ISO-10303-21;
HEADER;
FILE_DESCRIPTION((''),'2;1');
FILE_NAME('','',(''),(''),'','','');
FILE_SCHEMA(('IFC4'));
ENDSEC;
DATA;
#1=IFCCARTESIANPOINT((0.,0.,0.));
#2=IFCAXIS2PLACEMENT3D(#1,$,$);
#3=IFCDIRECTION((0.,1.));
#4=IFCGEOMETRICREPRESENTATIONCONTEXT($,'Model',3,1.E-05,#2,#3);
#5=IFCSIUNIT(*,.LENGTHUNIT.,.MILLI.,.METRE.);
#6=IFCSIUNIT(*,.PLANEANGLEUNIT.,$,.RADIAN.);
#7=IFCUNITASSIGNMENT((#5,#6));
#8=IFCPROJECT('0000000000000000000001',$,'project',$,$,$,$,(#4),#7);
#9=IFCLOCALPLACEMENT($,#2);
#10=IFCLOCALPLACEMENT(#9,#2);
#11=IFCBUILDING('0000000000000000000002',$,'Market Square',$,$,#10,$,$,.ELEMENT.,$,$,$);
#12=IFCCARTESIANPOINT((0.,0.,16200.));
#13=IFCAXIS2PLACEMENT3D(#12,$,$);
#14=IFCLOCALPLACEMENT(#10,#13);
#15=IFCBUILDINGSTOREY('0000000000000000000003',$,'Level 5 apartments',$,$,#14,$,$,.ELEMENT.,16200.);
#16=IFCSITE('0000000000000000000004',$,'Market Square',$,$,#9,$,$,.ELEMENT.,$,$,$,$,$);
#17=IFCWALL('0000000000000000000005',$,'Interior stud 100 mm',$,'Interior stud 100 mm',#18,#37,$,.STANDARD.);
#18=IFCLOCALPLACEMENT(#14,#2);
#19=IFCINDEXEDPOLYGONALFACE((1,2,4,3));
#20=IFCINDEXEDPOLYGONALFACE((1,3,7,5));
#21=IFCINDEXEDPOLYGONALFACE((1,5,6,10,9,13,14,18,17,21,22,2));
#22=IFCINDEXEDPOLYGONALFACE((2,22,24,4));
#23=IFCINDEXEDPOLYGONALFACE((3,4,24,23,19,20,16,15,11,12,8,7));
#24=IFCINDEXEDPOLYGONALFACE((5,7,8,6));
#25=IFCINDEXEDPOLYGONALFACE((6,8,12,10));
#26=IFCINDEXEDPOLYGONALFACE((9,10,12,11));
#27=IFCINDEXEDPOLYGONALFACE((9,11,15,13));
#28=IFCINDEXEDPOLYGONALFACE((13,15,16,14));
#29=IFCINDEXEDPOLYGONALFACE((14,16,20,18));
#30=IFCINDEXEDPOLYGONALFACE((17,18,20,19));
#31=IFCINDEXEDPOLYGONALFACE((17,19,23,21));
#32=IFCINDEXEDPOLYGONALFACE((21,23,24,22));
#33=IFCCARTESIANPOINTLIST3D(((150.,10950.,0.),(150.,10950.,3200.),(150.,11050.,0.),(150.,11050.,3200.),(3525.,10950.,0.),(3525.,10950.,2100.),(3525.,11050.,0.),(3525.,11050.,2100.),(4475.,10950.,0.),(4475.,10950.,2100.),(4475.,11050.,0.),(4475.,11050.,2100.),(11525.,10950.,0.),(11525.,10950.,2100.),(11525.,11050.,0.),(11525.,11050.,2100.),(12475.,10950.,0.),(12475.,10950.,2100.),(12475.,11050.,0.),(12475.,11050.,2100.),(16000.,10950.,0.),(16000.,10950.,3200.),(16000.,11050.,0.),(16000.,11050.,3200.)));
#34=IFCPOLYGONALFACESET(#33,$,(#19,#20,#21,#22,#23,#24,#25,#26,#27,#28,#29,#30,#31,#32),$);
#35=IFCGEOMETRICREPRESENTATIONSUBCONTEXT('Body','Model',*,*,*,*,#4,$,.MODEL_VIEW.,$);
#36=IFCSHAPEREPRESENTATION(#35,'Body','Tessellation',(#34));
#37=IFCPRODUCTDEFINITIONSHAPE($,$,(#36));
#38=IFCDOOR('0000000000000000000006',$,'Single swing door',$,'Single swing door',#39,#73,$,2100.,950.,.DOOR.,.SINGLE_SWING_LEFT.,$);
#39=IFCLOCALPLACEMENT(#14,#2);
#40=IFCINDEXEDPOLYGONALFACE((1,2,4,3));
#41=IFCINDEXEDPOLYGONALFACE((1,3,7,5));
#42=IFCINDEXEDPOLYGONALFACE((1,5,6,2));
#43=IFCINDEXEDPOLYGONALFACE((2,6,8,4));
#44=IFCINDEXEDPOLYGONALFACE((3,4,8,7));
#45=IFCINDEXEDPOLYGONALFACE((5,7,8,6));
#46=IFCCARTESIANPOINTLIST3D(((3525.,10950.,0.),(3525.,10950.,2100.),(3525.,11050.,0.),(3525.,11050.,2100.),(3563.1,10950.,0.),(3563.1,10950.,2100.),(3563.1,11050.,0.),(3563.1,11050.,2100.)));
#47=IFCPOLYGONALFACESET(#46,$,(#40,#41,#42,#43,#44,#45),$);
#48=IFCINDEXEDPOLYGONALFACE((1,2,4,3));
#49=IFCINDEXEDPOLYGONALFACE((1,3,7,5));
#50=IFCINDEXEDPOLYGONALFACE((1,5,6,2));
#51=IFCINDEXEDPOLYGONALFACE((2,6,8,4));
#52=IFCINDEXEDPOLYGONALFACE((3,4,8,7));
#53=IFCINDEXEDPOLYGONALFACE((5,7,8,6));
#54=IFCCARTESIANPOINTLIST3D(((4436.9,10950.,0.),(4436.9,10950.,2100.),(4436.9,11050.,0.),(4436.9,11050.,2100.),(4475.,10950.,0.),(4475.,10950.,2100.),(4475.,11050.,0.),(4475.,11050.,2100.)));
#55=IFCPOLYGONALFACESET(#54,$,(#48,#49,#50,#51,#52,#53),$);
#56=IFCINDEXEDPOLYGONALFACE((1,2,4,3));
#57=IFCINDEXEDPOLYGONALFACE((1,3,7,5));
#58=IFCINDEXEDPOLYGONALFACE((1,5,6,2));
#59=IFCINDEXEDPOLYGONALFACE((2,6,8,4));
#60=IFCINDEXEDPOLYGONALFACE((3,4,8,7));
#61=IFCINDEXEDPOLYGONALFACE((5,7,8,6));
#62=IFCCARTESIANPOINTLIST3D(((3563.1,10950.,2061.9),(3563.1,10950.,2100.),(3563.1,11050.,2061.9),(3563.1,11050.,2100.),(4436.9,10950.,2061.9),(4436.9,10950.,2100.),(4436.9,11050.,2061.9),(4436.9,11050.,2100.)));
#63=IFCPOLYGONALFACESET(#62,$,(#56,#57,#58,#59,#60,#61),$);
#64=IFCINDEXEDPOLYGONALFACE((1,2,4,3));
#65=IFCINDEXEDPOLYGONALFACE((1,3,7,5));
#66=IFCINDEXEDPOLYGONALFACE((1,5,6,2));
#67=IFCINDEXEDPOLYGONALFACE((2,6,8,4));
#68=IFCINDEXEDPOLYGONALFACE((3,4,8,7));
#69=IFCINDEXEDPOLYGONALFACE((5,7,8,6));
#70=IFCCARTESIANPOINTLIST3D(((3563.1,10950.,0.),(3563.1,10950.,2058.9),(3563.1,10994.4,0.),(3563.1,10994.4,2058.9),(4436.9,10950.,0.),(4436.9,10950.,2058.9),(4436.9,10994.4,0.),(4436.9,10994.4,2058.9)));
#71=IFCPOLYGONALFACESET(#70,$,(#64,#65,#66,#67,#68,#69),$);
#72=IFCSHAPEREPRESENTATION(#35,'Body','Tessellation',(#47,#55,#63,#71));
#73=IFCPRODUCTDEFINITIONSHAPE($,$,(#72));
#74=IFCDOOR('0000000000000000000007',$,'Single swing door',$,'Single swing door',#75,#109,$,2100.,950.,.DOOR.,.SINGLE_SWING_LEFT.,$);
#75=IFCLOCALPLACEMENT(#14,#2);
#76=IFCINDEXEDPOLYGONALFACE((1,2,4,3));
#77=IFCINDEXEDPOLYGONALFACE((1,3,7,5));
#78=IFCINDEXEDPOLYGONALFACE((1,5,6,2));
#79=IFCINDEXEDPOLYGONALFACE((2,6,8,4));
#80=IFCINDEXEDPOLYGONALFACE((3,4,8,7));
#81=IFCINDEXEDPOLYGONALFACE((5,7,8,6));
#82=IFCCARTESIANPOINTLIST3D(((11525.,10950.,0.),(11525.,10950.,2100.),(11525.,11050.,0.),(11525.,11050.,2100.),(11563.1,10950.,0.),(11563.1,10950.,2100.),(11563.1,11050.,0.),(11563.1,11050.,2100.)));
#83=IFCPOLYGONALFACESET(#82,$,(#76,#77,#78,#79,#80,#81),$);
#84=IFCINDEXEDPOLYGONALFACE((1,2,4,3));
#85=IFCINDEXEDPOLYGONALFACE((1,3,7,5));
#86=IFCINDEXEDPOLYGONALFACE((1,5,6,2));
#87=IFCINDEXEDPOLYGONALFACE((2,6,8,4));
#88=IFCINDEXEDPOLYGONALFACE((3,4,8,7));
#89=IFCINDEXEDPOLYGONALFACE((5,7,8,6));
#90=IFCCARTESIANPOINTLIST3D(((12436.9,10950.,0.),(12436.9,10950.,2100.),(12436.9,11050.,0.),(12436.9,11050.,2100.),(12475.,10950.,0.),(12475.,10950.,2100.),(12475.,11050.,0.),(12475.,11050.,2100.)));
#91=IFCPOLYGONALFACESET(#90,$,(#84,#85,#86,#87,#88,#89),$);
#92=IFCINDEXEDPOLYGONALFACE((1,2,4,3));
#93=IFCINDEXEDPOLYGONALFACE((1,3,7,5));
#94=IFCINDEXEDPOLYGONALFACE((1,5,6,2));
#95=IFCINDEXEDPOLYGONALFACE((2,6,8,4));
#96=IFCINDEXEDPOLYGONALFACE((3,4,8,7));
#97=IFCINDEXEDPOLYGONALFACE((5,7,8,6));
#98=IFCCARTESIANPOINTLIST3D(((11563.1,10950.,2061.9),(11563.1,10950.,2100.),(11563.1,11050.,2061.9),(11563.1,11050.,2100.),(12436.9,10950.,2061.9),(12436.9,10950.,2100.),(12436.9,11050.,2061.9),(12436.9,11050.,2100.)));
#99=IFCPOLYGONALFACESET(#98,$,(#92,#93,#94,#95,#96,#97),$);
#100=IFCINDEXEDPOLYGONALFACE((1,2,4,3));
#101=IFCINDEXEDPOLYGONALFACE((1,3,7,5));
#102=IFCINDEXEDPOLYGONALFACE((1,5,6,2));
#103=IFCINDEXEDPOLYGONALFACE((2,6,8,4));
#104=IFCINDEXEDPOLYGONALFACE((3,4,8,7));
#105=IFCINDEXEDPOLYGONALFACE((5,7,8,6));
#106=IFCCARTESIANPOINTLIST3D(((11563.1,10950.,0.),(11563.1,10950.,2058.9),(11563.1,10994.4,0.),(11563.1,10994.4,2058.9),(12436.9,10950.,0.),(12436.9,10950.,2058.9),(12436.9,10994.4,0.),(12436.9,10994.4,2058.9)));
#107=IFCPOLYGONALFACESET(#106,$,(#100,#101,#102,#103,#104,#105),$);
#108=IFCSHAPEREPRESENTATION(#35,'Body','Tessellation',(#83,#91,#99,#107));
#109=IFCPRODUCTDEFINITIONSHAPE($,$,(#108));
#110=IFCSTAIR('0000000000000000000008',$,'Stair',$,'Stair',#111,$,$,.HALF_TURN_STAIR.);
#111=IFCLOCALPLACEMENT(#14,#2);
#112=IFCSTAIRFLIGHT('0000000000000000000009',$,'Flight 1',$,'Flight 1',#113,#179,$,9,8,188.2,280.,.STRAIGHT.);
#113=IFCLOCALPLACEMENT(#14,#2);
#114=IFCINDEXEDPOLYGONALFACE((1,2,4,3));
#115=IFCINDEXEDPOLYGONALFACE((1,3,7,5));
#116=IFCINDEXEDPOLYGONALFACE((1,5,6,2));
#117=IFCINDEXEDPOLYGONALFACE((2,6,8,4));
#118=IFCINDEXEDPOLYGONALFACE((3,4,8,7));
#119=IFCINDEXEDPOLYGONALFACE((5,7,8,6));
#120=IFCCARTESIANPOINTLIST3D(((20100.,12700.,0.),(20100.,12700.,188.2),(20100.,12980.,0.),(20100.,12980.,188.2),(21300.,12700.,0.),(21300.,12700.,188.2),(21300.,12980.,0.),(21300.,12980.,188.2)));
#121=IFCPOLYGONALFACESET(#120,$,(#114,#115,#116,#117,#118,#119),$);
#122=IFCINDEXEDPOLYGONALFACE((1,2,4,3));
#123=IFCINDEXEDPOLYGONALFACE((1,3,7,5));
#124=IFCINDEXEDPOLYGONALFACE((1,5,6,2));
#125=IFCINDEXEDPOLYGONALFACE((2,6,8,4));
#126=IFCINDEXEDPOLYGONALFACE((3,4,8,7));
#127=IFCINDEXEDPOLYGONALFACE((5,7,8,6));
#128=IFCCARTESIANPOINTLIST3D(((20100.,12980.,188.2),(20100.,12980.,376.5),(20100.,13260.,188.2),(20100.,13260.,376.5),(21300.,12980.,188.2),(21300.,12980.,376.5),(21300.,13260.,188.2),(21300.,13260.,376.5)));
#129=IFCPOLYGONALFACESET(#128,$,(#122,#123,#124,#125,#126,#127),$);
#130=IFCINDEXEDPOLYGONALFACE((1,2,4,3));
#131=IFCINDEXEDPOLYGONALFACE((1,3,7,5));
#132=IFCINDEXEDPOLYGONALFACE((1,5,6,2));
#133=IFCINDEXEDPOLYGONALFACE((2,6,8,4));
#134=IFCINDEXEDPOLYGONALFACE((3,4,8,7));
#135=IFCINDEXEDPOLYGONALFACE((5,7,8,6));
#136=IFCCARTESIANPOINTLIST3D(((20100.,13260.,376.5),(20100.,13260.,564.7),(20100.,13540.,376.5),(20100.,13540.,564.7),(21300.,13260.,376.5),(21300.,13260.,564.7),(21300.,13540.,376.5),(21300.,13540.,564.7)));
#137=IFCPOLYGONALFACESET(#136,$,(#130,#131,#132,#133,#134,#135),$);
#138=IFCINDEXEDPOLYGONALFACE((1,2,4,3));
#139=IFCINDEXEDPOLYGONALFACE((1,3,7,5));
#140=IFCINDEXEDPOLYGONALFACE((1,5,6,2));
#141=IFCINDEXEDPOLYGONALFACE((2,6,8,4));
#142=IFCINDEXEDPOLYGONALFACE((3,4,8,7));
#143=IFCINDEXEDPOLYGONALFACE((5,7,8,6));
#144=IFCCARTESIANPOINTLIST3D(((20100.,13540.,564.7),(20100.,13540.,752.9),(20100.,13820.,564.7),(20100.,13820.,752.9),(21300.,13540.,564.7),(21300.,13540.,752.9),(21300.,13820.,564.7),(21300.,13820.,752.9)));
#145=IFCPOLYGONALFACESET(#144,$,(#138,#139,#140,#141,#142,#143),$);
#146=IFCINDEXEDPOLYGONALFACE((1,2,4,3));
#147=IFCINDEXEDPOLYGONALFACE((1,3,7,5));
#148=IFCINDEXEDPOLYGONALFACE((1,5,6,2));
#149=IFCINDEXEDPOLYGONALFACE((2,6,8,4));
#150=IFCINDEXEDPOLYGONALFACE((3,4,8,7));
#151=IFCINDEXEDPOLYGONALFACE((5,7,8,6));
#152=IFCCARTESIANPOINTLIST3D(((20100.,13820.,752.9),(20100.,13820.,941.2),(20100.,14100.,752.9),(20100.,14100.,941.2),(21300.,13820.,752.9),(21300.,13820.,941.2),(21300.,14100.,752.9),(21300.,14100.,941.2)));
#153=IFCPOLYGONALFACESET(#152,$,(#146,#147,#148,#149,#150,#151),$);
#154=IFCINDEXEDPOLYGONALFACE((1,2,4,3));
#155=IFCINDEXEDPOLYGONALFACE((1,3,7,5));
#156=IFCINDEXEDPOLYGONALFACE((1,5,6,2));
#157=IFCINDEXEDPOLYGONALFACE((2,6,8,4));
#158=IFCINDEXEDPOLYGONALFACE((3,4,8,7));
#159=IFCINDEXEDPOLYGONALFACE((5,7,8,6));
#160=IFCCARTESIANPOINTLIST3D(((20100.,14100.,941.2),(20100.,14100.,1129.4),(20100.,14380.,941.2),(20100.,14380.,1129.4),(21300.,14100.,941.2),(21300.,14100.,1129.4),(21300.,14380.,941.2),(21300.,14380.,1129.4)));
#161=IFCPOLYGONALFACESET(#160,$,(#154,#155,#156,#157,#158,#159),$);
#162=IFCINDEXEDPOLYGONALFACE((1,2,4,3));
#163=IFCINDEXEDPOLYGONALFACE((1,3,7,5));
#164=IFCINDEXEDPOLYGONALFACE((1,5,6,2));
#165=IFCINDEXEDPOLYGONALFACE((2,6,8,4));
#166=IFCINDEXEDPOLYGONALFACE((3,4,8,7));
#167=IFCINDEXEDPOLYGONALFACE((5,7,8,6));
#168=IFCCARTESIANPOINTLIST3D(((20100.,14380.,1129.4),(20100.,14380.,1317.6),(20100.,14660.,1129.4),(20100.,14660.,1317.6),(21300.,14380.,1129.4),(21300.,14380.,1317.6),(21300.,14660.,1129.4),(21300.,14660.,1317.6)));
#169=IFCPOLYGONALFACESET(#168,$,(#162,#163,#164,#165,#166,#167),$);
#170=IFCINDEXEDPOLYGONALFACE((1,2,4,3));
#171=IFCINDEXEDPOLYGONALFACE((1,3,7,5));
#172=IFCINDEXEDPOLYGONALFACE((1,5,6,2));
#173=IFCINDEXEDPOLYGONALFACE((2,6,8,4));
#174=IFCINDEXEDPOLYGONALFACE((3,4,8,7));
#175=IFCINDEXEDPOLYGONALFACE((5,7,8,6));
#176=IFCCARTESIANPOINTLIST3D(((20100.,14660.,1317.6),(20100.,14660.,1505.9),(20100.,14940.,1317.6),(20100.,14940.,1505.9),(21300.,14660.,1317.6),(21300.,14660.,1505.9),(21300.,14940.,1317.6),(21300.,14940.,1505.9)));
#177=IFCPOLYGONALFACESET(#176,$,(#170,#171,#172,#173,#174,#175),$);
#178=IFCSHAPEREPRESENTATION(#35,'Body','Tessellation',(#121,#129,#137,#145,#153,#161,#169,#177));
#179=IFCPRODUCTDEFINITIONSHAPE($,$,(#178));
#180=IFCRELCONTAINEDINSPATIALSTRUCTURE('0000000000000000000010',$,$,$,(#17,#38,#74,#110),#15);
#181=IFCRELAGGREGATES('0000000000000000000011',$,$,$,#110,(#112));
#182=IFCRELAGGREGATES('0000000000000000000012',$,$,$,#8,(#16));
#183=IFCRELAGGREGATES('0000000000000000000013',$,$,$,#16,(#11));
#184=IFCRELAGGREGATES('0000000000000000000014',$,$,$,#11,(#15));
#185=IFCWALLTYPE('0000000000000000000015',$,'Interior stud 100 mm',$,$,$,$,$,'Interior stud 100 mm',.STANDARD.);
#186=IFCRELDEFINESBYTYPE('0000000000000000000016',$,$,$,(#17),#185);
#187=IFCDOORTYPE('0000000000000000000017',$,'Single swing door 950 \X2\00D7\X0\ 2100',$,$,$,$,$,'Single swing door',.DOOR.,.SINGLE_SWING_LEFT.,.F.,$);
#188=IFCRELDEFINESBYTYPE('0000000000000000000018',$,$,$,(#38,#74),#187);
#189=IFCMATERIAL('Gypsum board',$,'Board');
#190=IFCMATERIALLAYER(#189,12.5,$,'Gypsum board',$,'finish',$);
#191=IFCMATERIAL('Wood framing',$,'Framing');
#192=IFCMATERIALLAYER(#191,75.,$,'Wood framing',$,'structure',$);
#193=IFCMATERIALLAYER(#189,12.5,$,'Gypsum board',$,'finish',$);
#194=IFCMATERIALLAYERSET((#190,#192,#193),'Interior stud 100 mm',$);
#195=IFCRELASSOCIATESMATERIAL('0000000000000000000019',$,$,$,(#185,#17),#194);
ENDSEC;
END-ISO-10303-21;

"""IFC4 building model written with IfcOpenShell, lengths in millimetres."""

from ifc_helpers import new_model, si_unit, direction, frame, origin, origin_with_axes, place, context, subcontext, project, spatial, polyline, outline, extrude, material, layer, layer_set, layer_usage, type_object, element, fill, aggregate, save


model = new_model("IFC4")

# Units and contexts
model_context = context("Model", 3, precision=1e-05, world=origin(), true_north=direction((0.0, 1.0)))
body_context = subcontext(model_context, "Body", "Model", "MODEL_VIEW")
ifc_project = project(units=[si_unit("LENGTHUNIT", "METRE", prefix="MILLI"), si_unit("PLANEANGLEUNIT", "RADIAN")], contexts=[model_context])

# Site, building, storey
site_placement = place(None, origin())
site = spatial("IfcSite", under=ifc_project, at=site_placement, Name="Market Square", CompositionType="ELEMENT")
building_placement = place(site_placement, origin())
building = spatial("IfcBuilding", under=site, at=building_placement, Name="Market Square", CompositionType="ELEMENT")
storey_placement = place(building_placement, frame((0.0, 0.0, 16200.0)))
storey = spatial("IfcBuildingStorey", under=building, at=storey_placement, Name="Level 5 apartments", CompositionType="ELEMENT", Elevation=16200.0)

# Wall, openings, doors
ifc_material_1 = material(Name="Gypsum board", Category="Board")
ifc_layer_1 = layer(ifc_material_1, 12.5, Name="Gypsum board", Category="finish")
ifc_material_2 = material(Name="Wood framing", Category="Framing")
ifc_layer_2 = layer(ifc_material_2, 75.0, Name="Wood framing", Category="structure")
ifc_layer_3 = layer(ifc_material_1, 12.5, Name="Gypsum board", Category="finish")
ifc_layer_set_1 = layer_set([ifc_layer_1, ifc_layer_2, ifc_layer_3], Name="Interior stud 100 mm")
wall_type_1 = type_object("IfcWallType", Name="Interior stud 100 mm", ElementType="Interior stud 100 mm", PredefinedType="STANDARD", material=ifc_layer_set_1)
door_type = type_object("IfcDoorType", Name="Single swing door 950 × 2100", ElementType="Single swing door", OperationType="SINGLE_SWING_LEFT", ParameterTakesPrecedence=False, PredefinedType="DOOR")
ifc_layer_usage_1 = layer_usage(ifc_layer_set_1, "AXIS2", "NEGATIVE", 50.0)
wall_1_placement = place(storey_placement, frame((0.0, 11000.0, 0.0), z_axis=(0.0, 0.0, 1.0), x_axis=(1.0, 0.0, 0.0)))
wall_1 = element("IfcWall", 1, at=wall_1_placement, inside=storey, type_object=wall_type_1, material=ifc_layer_usage_1, Name="Interior stud 100 mm", ObjectType="Interior stud 100 mm", PredefinedType="STANDARD", context=body_context, shape_type="SweptSolid", body=[
    extrude(outline(polyline([(150.0, -50.0), (16000.0, -50.0), (16000.0, 50.0), (150.0, 50.0), (150.0, -50.0)])), origin(), (0.0, 0.0, 1.0), 3200.0),
])
opening_1_placement = place(wall_1_placement, frame((3525.0, 0.0, 0.0), z_axis=(0.0, 0.0, 1.0), x_axis=(1.0, 0.0, 0.0)))
opening_1 = element("IfcOpeningElement", 2, at=opening_1_placement, cuts=wall_1, PredefinedType="OPENING", context=body_context, shape_type="SweptSolid", body=[
    extrude(outline(polyline([(0.0, -60.0), (950.0, -60.0), (950.0, 60.0), (0.0, 60.0), (0.0, -60.0)])), origin(), (0.0, 0.0, 1.0), 2100.0),
])
opening_2_placement = place(wall_1_placement, frame((11525.0, 0.0, 0.0), z_axis=(0.0, 0.0, 1.0), x_axis=(1.0, 0.0, 0.0)))
opening_2 = element("IfcOpeningElement", 3, at=opening_2_placement, cuts=wall_1, PredefinedType="OPENING", context=body_context, shape_type="SweptSolid", body=[
    extrude(outline(polyline([(0.0, -60.0), (950.0, -60.0), (950.0, 60.0), (0.0, 60.0), (0.0, -60.0)])), origin(), (0.0, 0.0, 1.0), 2100.0),
])
door_1_placement = place(opening_1_placement, origin_with_axes())
door_1 = element("IfcDoor", 4, at=door_1_placement, inside=storey, type_object=door_type, Name="Single swing door", ObjectType="Single swing door", OperationType="SINGLE_SWING_LEFT", OverallHeight=2100.0, OverallWidth=950.0, PredefinedType="DOOR", context=body_context, shape_type="SweptSolid", body=[
    extrude(outline(polyline([(0.0, -50.0), (38.1, -50.0), (38.1, 50.0), (0.0, 50.0), (0.0, -50.0)])), origin(), (0.0, 0.0, 1.0), 2100.0),
    extrude(outline(polyline([(911.9, -50.0), (950.0, -50.0), (950.0, 50.0), (911.9, 50.0), (911.9, -50.0)])), origin(), (0.0, 0.0, 1.0), 2100.0),
    extrude(outline(polyline([(38.1, -50.0), (911.9, -50.0), (911.9, 50.0), (38.1, 50.0), (38.1, -50.0)])), frame((0.0, 0.0, 2061.9)), (0.0, 0.0, 1.0), 38.1),
    extrude(outline(polyline([(38.1, -50.0), (911.9, -50.0), (911.9, -5.5), (38.1, -5.5), (38.1, -50.0)])), origin(), (0.0, 0.0, 1.0), 2058.9),
])
fill(opening_1, door_1)
door_2_placement = place(opening_2_placement, origin_with_axes())
door_2 = element("IfcDoor", 5, at=door_2_placement, inside=storey, type_object=door_type, Name="Single swing door", ObjectType="Single swing door", OperationType="SINGLE_SWING_LEFT", OverallHeight=2100.0, OverallWidth=950.0, PredefinedType="DOOR", context=body_context, shape_type="SweptSolid", body=[
    extrude(outline(polyline([(0.0, -50.0), (38.1, -50.0), (38.1, 50.0), (0.0, 50.0), (0.0, -50.0)])), origin(), (0.0, 0.0, 1.0), 2100.0),
    extrude(outline(polyline([(911.9, -50.0), (950.0, -50.0), (950.0, 50.0), (911.9, 50.0), (911.9, -50.0)])), origin(), (0.0, 0.0, 1.0), 2100.0),
    extrude(outline(polyline([(38.1, -50.0), (911.9, -50.0), (911.9, 50.0), (38.1, 50.0), (38.1, -50.0)])), frame((0.0, 0.0, 2061.9)), (0.0, 0.0, 1.0), 38.1),
    extrude(outline(polyline([(38.1, -50.0), (911.9, -50.0), (911.9, -5.5), (38.1, -5.5), (38.1, -50.0)])), origin(), (0.0, 0.0, 1.0), 2058.9),
])
fill(opening_2, door_2)

# Stair, stair flight
stair_placement = place(storey_placement, origin_with_axes())
stair = element("IfcStair", 6, at=stair_placement, inside=storey, Name="Stair", ObjectType="Stair", PredefinedType="HALF_TURN_STAIR")
stair_flight_placement = place(storey_placement, origin_with_axes())
stair_flight = element("IfcStairFlight", 7, at=stair_flight_placement, Name="Flight 1", ObjectType="Flight 1", NumberOfRisers=9, NumberOfTreads=8, PredefinedType="STRAIGHT", RiserHeight=188.2, TreadLength=280.0, context=body_context, shape_type="SweptSolid", body=[
    extrude(outline(polyline([(21300.0, 12700.0), (21300.0, 12980.0), (20100.0, 12980.0), (20100.0, 12700.0), (21300.0, 12700.0)])), origin(), (0.0, 0.0, 1.0), 188.2),
    extrude(outline(polyline([(21300.0, 12980.0), (21300.0, 13260.0), (20100.0, 13260.0), (20100.0, 12980.0), (21300.0, 12980.0)])), frame((0.0, 0.0, 188.2)), (0.0, 0.0, 1.0), 188.2),
    extrude(outline(polyline([(21300.0, 13260.0), (21300.0, 13540.0), (20100.0, 13540.0), (20100.0, 13260.0), (21300.0, 13260.0)])), frame((0.0, 0.0, 376.5)), (0.0, 0.0, 1.0), 188.2),
    extrude(outline(polyline([(21300.0, 13540.0), (21300.0, 13820.0), (20100.0, 13820.0), (20100.0, 13540.0), (21300.0, 13540.0)])), frame((0.0, 0.0, 564.7)), (0.0, 0.0, 1.0), 188.2),
    extrude(outline(polyline([(21300.0, 13820.0), (21300.0, 14100.0), (20100.0, 14100.0), (20100.0, 13820.0), (21300.0, 13820.0)])), frame((0.0, 0.0, 752.9)), (0.0, 0.0, 1.0), 188.2),
    extrude(outline(polyline([(21300.0, 14100.0), (21300.0, 14380.0), (20100.0, 14380.0), (20100.0, 14100.0), (21300.0, 14100.0)])), frame((0.0, 0.0, 941.2)), (0.0, 0.0, 1.0), 188.2),
    extrude(outline(polyline([(21300.0, 14380.0), (21300.0, 14660.0), (20100.0, 14660.0), (20100.0, 14380.0), (21300.0, 14380.0)])), frame((0.0, 0.0, 1129.4)), (0.0, 0.0, 1.0), 188.2),
    extrude(outline(polyline([(21300.0, 14660.0), (21300.0, 14940.0), (20100.0, 14940.0), (20100.0, 14660.0), (21300.0, 14660.0)])), frame((0.0, 0.0, 1317.6)), (0.0, 0.0, 1.0), 188.2),
])
aggregate(stair, [stair_flight])

save(model, "model.ifc")
